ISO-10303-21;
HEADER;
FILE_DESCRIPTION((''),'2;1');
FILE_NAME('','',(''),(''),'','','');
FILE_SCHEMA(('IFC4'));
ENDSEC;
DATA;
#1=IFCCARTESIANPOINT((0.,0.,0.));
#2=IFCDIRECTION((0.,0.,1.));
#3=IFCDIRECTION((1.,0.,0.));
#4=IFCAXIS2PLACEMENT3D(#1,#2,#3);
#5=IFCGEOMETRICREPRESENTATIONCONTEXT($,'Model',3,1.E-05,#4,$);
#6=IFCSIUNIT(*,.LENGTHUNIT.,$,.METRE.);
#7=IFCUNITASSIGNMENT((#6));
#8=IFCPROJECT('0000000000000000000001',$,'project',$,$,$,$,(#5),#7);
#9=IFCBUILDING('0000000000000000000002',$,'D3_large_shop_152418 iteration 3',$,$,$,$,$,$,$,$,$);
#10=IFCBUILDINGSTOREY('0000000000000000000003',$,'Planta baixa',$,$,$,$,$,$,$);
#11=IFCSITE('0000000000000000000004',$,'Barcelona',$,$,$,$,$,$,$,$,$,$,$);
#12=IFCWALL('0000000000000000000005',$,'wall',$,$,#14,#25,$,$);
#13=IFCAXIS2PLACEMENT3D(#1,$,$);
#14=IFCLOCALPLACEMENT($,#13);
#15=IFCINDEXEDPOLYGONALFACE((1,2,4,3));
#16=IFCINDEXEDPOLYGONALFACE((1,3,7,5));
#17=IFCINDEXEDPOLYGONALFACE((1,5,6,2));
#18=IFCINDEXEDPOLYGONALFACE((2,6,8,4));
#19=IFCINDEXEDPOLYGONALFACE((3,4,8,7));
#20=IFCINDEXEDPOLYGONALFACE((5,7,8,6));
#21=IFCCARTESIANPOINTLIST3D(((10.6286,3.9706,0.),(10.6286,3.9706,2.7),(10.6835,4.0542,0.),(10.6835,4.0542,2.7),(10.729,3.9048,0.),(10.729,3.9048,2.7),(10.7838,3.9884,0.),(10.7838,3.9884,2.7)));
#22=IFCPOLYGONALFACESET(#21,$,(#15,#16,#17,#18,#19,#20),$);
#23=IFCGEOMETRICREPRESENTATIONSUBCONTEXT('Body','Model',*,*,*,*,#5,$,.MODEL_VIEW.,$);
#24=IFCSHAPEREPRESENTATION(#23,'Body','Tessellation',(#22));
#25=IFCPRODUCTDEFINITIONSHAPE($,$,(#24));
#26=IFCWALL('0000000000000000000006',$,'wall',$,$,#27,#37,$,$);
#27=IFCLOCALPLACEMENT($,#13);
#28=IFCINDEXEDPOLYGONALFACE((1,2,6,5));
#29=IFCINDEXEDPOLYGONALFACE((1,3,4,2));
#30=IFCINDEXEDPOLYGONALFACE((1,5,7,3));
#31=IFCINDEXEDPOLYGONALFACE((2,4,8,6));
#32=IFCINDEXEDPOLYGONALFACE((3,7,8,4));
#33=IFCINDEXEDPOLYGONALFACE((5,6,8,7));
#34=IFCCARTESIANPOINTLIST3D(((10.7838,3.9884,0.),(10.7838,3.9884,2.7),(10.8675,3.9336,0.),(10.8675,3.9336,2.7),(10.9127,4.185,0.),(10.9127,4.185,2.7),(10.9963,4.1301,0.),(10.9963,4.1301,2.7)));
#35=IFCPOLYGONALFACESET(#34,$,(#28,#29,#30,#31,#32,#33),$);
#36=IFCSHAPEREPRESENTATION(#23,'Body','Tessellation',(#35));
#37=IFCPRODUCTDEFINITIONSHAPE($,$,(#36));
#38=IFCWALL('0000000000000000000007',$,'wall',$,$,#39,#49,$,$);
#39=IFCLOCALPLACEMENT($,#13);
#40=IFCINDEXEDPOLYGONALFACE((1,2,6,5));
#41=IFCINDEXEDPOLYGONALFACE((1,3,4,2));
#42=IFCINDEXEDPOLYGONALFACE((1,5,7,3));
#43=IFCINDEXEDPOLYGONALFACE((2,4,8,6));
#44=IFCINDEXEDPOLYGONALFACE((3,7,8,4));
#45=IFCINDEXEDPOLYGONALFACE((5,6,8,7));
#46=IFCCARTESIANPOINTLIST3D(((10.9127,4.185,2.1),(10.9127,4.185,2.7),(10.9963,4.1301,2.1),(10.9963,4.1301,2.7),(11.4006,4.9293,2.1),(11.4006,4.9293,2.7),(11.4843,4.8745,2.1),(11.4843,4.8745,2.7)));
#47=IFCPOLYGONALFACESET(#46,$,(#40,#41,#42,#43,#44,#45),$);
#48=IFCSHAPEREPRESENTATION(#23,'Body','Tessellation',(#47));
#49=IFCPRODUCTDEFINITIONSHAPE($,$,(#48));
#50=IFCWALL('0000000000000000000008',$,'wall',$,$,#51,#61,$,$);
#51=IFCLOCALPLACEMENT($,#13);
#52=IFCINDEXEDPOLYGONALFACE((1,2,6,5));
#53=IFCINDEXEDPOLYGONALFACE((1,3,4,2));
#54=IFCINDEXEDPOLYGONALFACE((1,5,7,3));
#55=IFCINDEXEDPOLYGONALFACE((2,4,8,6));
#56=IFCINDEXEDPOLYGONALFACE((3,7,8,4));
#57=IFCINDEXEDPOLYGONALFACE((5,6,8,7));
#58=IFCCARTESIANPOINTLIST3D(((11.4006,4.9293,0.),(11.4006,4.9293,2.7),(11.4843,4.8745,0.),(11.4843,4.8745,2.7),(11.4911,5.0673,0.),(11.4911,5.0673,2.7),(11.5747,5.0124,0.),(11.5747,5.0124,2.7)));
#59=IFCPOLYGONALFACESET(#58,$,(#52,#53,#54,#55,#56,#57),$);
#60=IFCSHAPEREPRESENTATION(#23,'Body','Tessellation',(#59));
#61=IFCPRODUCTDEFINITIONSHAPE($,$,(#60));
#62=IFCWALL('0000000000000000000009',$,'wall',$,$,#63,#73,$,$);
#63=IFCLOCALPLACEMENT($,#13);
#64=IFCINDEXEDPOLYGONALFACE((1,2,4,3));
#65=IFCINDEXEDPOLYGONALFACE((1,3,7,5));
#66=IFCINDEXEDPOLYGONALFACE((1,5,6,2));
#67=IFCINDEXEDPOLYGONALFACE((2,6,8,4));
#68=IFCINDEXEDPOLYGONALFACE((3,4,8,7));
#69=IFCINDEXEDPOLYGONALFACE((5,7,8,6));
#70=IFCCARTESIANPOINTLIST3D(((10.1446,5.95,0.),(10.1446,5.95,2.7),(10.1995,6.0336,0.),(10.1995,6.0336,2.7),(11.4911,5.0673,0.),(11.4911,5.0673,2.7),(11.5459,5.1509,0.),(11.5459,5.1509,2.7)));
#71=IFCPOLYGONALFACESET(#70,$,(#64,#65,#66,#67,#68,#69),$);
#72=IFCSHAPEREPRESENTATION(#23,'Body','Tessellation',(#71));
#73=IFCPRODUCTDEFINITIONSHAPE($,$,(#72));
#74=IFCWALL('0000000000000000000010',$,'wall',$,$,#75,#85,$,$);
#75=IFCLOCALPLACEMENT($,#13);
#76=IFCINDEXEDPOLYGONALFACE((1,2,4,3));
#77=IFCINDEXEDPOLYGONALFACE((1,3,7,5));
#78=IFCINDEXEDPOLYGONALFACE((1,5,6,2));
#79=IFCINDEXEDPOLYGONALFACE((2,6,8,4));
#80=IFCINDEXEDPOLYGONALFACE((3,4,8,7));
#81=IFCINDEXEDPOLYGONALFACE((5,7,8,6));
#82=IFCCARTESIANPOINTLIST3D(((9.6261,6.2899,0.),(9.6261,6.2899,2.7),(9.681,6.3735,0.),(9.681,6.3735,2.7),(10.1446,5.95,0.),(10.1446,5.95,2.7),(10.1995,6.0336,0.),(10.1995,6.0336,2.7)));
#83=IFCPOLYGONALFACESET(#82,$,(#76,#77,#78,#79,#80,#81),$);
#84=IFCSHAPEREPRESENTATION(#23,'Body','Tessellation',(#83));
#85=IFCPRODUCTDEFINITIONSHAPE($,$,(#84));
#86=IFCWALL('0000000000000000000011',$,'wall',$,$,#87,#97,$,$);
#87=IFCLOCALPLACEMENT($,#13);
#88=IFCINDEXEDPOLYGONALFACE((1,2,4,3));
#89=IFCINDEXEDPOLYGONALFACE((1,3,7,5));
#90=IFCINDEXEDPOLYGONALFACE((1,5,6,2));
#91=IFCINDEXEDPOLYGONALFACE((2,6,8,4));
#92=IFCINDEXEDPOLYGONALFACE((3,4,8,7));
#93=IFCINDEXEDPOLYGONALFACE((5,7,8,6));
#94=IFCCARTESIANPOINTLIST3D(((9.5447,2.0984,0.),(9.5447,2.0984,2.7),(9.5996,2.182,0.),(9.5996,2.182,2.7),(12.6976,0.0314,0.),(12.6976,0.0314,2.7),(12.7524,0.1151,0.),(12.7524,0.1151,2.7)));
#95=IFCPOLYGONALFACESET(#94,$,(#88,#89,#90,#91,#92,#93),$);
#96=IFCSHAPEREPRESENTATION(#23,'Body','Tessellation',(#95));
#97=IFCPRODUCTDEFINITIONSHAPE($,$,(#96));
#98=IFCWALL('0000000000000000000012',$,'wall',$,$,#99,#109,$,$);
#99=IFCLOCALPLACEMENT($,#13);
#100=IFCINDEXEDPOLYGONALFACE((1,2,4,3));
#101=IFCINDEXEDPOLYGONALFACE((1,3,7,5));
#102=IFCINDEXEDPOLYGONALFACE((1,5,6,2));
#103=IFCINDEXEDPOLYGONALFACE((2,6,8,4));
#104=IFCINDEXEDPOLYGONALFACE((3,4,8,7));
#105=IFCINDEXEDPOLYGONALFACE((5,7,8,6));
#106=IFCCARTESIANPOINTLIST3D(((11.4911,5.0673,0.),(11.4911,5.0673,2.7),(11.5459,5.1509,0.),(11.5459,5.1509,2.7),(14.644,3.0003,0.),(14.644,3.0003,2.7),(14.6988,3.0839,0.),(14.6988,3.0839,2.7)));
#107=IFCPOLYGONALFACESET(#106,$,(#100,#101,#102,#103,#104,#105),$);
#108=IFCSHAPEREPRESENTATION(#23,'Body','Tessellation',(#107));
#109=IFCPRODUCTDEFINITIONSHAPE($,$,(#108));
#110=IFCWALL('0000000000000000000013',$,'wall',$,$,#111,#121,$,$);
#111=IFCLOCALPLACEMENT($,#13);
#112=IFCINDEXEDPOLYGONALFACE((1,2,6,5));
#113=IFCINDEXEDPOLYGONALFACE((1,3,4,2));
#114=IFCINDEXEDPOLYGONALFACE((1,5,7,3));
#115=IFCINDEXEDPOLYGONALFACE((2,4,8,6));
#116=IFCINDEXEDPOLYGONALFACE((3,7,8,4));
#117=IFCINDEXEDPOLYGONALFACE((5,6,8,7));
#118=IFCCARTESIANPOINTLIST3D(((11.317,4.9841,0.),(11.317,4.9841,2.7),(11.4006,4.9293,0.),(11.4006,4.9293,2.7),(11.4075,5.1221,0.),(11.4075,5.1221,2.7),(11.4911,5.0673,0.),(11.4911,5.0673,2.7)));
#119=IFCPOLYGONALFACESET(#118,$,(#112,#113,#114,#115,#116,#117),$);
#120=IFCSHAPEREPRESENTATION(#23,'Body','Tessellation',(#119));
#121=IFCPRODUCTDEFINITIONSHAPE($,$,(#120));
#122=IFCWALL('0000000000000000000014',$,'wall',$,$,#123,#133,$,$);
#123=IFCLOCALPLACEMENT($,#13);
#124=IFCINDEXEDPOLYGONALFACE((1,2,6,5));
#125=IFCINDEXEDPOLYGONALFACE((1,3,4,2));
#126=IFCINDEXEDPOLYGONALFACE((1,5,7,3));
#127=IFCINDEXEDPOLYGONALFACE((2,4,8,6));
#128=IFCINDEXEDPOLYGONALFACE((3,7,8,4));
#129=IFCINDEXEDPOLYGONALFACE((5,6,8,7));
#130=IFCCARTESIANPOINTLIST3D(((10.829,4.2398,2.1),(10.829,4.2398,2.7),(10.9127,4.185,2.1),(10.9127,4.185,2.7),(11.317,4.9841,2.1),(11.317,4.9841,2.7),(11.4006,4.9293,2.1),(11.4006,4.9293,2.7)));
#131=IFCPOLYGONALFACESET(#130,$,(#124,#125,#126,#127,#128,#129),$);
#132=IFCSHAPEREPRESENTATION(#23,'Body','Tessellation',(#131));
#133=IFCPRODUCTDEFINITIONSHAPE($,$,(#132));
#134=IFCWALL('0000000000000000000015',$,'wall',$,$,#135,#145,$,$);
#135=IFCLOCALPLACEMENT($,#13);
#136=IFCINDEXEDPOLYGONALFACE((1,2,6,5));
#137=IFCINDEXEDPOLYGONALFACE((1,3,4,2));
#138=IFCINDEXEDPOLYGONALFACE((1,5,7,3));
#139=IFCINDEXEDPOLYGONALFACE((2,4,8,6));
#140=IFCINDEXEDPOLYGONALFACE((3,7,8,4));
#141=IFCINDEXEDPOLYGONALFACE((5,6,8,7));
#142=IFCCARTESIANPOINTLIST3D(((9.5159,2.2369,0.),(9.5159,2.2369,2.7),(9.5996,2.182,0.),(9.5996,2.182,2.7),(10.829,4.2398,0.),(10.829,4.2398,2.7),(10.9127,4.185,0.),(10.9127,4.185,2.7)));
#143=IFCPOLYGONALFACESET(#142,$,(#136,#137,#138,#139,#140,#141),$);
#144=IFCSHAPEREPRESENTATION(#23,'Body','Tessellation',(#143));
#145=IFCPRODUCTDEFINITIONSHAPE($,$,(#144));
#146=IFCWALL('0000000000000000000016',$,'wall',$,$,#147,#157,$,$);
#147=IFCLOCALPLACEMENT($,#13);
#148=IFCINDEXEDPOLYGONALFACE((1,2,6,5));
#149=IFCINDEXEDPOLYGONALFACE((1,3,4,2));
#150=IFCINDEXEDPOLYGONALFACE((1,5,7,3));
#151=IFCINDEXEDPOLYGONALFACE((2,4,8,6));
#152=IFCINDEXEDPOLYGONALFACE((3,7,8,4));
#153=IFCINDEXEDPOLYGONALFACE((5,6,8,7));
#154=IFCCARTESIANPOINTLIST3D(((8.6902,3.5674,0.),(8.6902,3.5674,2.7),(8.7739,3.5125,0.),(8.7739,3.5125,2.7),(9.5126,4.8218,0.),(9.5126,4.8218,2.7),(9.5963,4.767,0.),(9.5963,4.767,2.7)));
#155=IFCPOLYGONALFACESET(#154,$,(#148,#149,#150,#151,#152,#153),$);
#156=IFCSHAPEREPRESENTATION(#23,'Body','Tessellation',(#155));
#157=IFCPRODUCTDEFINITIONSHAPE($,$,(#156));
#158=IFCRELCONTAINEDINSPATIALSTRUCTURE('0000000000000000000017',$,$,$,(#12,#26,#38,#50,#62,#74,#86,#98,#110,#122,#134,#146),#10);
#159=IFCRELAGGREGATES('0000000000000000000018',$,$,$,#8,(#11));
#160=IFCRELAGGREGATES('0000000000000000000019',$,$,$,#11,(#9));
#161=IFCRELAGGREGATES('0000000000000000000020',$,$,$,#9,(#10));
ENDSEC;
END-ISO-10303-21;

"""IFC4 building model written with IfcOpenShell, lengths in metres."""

from ifc_helpers import new_model, si_unit, frame, origin, origin_with_axes, place, context, subcontext, project, spatial, polyline, outline, extrude, element, save


model = new_model("IFC4")

# Units and contexts
model_context = context("Model", 3, precision=1e-05, world=origin_with_axes())
body_context = subcontext(model_context, "Body", "Model", "MODEL_VIEW")
ifc_project = project(units=[si_unit("LENGTHUNIT", "METRE")], contexts=[model_context])

# Site, building, storey
site = spatial("IfcSite", under=ifc_project, Name="Barcelona")
building = spatial("IfcBuilding", under=site, Name="D3_large_shop_152418 iteration 3")
storey = spatial("IfcBuildingStorey", under=building, Name="Planta baixa")

# Walls
wall_1_placement = place(None, origin_with_axes())
element("IfcWall", 1, at=wall_1_placement, inside=storey, Name="wall", context=body_context, shape_type="SweptSolid", body=[
    extrude(outline(polyline([(10.6835, 4.0542), (10.7838, 3.9884), (10.729, 3.9048), (10.6286, 3.9706), (10.6835, 4.0542)])), origin(), (0.0, 0.0, 1.0), 2.7),
])
wall_2_placement = place(None, origin_with_axes())
element("IfcWall", 2, at=wall_2_placement, inside=storey, Name="wall", context=body_context, shape_type="SweptSolid", body=[
    extrude(outline(polyline([(10.7838, 3.9884), (10.9127, 4.185), (10.9963, 4.1301), (10.8675, 3.9336), (10.7838, 3.9884)])), origin(), (0.0, 0.0, 1.0), 2.7),
])
wall_3_placement = place(None, origin_with_axes())
element("IfcWall", 3, at=wall_3_placement, inside=storey, Name="wall", context=body_context, shape_type="SweptSolid", body=[
    extrude(outline(polyline([(10.9127, 4.185), (11.4006, 4.9293), (11.4843, 4.8745), (10.9963, 4.1301), (10.9127, 4.185)])), frame((0.0, 0.0, 2.1)), (0.0, 0.0, 1.0), 0.6),
])
wall_4_placement = place(None, origin_with_axes())
element("IfcWall", 4, at=wall_4_placement, inside=storey, Name="wall", context=body_context, shape_type="SweptSolid", body=[
    extrude(outline(polyline([(11.4006, 4.9293), (11.4911, 5.0673), (11.5747, 5.0124), (11.4843, 4.8745), (11.4006, 4.9293)])), origin(), (0.0, 0.0, 1.0), 2.7),
])
wall_5_placement = place(None, origin_with_axes())
element("IfcWall", 5, at=wall_5_placement, inside=storey, Name="wall", context=body_context, shape_type="SweptSolid", body=[
    extrude(outline(polyline([(11.4911, 5.0673), (10.1446, 5.95), (10.1995, 6.0336), (11.5459, 5.1509), (11.4911, 5.0673)])), origin(), (0.0, 0.0, 1.0), 2.7),
])
wall_6_placement = place(None, origin_with_axes())
element("IfcWall", 6, at=wall_6_placement, inside=storey, Name="wall", context=body_context, shape_type="SweptSolid", body=[
    extrude(outline(polyline([(10.1446, 5.95), (9.6261, 6.2899), (9.681, 6.3735), (10.1995, 6.0336), (10.1446, 5.95)])), origin(), (0.0, 0.0, 1.0), 2.7),
])
wall_7_placement = place(None, origin_with_axes())
element("IfcWall", 7, at=wall_7_placement, inside=storey, Name="wall", context=body_context, shape_type="SweptSolid", body=[
    extrude(outline(polyline([(9.5996, 2.182), (12.7524, 0.1151), (12.6976, 0.0314), (9.5447, 2.0984), (9.5996, 2.182)])), origin(), (0.0, 0.0, 1.0), 2.7),
])
wall_8_placement = place(None, origin_with_axes())
element("IfcWall", 8, at=wall_8_placement, inside=storey, Name="wall", context=body_context, shape_type="SweptSolid", body=[
    extrude(outline(polyline([(14.644, 3.0003), (11.4911, 5.0673), (11.5459, 5.1509), (14.6988, 3.0839), (14.644, 3.0003)])), origin(), (0.0, 0.0, 1.0), 2.7),
])
wall_9_placement = place(None, origin_with_axes())
element("IfcWall", 9, at=wall_9_placement, inside=storey, Name="wall", context=body_context, shape_type="SweptSolid", body=[
    extrude(outline(polyline([(11.4911, 5.0673), (11.4006, 4.9293), (11.317, 4.9841), (11.4075, 5.1221), (11.4911, 5.0673)])), origin(), (0.0, 0.0, 1.0), 2.7),
])
wall_10_placement = place(None, origin_with_axes())
element("IfcWall", 10, at=wall_10_placement, inside=storey, Name="wall", context=body_context, shape_type="SweptSolid", body=[
    extrude(outline(polyline([(11.4006, 4.9293), (10.9127, 4.185), (10.829, 4.2398), (11.317, 4.9841), (11.4006, 4.9293)])), frame((0.0, 0.0, 2.1)), (0.0, 0.0, 1.0), 0.6),
])
wall_11_placement = place(None, origin_with_axes())
element("IfcWall", 11, at=wall_11_placement, inside=storey, Name="wall", context=body_context, shape_type="SweptSolid", body=[
    extrude(outline(polyline([(10.9127, 4.185), (9.5996, 2.182), (9.5159, 2.2369), (10.829, 4.2398), (10.9127, 4.185)])), origin(), (0.0, 0.0, 1.0), 2.7),
])
wall_12_placement = place(None, origin_with_axes())
element("IfcWall", 12, at=wall_12_placement, inside=storey, Name="wall", context=body_context, shape_type="SweptSolid", body=[
    extrude(outline(polyline([(9.5963, 4.767), (8.7739, 3.5125), (8.6902, 3.5674), (9.5126, 4.8218), (9.5963, 4.767)])), origin(), (0.0, 0.0, 1.0), 2.7),
])

save(model, "model.ifc")
